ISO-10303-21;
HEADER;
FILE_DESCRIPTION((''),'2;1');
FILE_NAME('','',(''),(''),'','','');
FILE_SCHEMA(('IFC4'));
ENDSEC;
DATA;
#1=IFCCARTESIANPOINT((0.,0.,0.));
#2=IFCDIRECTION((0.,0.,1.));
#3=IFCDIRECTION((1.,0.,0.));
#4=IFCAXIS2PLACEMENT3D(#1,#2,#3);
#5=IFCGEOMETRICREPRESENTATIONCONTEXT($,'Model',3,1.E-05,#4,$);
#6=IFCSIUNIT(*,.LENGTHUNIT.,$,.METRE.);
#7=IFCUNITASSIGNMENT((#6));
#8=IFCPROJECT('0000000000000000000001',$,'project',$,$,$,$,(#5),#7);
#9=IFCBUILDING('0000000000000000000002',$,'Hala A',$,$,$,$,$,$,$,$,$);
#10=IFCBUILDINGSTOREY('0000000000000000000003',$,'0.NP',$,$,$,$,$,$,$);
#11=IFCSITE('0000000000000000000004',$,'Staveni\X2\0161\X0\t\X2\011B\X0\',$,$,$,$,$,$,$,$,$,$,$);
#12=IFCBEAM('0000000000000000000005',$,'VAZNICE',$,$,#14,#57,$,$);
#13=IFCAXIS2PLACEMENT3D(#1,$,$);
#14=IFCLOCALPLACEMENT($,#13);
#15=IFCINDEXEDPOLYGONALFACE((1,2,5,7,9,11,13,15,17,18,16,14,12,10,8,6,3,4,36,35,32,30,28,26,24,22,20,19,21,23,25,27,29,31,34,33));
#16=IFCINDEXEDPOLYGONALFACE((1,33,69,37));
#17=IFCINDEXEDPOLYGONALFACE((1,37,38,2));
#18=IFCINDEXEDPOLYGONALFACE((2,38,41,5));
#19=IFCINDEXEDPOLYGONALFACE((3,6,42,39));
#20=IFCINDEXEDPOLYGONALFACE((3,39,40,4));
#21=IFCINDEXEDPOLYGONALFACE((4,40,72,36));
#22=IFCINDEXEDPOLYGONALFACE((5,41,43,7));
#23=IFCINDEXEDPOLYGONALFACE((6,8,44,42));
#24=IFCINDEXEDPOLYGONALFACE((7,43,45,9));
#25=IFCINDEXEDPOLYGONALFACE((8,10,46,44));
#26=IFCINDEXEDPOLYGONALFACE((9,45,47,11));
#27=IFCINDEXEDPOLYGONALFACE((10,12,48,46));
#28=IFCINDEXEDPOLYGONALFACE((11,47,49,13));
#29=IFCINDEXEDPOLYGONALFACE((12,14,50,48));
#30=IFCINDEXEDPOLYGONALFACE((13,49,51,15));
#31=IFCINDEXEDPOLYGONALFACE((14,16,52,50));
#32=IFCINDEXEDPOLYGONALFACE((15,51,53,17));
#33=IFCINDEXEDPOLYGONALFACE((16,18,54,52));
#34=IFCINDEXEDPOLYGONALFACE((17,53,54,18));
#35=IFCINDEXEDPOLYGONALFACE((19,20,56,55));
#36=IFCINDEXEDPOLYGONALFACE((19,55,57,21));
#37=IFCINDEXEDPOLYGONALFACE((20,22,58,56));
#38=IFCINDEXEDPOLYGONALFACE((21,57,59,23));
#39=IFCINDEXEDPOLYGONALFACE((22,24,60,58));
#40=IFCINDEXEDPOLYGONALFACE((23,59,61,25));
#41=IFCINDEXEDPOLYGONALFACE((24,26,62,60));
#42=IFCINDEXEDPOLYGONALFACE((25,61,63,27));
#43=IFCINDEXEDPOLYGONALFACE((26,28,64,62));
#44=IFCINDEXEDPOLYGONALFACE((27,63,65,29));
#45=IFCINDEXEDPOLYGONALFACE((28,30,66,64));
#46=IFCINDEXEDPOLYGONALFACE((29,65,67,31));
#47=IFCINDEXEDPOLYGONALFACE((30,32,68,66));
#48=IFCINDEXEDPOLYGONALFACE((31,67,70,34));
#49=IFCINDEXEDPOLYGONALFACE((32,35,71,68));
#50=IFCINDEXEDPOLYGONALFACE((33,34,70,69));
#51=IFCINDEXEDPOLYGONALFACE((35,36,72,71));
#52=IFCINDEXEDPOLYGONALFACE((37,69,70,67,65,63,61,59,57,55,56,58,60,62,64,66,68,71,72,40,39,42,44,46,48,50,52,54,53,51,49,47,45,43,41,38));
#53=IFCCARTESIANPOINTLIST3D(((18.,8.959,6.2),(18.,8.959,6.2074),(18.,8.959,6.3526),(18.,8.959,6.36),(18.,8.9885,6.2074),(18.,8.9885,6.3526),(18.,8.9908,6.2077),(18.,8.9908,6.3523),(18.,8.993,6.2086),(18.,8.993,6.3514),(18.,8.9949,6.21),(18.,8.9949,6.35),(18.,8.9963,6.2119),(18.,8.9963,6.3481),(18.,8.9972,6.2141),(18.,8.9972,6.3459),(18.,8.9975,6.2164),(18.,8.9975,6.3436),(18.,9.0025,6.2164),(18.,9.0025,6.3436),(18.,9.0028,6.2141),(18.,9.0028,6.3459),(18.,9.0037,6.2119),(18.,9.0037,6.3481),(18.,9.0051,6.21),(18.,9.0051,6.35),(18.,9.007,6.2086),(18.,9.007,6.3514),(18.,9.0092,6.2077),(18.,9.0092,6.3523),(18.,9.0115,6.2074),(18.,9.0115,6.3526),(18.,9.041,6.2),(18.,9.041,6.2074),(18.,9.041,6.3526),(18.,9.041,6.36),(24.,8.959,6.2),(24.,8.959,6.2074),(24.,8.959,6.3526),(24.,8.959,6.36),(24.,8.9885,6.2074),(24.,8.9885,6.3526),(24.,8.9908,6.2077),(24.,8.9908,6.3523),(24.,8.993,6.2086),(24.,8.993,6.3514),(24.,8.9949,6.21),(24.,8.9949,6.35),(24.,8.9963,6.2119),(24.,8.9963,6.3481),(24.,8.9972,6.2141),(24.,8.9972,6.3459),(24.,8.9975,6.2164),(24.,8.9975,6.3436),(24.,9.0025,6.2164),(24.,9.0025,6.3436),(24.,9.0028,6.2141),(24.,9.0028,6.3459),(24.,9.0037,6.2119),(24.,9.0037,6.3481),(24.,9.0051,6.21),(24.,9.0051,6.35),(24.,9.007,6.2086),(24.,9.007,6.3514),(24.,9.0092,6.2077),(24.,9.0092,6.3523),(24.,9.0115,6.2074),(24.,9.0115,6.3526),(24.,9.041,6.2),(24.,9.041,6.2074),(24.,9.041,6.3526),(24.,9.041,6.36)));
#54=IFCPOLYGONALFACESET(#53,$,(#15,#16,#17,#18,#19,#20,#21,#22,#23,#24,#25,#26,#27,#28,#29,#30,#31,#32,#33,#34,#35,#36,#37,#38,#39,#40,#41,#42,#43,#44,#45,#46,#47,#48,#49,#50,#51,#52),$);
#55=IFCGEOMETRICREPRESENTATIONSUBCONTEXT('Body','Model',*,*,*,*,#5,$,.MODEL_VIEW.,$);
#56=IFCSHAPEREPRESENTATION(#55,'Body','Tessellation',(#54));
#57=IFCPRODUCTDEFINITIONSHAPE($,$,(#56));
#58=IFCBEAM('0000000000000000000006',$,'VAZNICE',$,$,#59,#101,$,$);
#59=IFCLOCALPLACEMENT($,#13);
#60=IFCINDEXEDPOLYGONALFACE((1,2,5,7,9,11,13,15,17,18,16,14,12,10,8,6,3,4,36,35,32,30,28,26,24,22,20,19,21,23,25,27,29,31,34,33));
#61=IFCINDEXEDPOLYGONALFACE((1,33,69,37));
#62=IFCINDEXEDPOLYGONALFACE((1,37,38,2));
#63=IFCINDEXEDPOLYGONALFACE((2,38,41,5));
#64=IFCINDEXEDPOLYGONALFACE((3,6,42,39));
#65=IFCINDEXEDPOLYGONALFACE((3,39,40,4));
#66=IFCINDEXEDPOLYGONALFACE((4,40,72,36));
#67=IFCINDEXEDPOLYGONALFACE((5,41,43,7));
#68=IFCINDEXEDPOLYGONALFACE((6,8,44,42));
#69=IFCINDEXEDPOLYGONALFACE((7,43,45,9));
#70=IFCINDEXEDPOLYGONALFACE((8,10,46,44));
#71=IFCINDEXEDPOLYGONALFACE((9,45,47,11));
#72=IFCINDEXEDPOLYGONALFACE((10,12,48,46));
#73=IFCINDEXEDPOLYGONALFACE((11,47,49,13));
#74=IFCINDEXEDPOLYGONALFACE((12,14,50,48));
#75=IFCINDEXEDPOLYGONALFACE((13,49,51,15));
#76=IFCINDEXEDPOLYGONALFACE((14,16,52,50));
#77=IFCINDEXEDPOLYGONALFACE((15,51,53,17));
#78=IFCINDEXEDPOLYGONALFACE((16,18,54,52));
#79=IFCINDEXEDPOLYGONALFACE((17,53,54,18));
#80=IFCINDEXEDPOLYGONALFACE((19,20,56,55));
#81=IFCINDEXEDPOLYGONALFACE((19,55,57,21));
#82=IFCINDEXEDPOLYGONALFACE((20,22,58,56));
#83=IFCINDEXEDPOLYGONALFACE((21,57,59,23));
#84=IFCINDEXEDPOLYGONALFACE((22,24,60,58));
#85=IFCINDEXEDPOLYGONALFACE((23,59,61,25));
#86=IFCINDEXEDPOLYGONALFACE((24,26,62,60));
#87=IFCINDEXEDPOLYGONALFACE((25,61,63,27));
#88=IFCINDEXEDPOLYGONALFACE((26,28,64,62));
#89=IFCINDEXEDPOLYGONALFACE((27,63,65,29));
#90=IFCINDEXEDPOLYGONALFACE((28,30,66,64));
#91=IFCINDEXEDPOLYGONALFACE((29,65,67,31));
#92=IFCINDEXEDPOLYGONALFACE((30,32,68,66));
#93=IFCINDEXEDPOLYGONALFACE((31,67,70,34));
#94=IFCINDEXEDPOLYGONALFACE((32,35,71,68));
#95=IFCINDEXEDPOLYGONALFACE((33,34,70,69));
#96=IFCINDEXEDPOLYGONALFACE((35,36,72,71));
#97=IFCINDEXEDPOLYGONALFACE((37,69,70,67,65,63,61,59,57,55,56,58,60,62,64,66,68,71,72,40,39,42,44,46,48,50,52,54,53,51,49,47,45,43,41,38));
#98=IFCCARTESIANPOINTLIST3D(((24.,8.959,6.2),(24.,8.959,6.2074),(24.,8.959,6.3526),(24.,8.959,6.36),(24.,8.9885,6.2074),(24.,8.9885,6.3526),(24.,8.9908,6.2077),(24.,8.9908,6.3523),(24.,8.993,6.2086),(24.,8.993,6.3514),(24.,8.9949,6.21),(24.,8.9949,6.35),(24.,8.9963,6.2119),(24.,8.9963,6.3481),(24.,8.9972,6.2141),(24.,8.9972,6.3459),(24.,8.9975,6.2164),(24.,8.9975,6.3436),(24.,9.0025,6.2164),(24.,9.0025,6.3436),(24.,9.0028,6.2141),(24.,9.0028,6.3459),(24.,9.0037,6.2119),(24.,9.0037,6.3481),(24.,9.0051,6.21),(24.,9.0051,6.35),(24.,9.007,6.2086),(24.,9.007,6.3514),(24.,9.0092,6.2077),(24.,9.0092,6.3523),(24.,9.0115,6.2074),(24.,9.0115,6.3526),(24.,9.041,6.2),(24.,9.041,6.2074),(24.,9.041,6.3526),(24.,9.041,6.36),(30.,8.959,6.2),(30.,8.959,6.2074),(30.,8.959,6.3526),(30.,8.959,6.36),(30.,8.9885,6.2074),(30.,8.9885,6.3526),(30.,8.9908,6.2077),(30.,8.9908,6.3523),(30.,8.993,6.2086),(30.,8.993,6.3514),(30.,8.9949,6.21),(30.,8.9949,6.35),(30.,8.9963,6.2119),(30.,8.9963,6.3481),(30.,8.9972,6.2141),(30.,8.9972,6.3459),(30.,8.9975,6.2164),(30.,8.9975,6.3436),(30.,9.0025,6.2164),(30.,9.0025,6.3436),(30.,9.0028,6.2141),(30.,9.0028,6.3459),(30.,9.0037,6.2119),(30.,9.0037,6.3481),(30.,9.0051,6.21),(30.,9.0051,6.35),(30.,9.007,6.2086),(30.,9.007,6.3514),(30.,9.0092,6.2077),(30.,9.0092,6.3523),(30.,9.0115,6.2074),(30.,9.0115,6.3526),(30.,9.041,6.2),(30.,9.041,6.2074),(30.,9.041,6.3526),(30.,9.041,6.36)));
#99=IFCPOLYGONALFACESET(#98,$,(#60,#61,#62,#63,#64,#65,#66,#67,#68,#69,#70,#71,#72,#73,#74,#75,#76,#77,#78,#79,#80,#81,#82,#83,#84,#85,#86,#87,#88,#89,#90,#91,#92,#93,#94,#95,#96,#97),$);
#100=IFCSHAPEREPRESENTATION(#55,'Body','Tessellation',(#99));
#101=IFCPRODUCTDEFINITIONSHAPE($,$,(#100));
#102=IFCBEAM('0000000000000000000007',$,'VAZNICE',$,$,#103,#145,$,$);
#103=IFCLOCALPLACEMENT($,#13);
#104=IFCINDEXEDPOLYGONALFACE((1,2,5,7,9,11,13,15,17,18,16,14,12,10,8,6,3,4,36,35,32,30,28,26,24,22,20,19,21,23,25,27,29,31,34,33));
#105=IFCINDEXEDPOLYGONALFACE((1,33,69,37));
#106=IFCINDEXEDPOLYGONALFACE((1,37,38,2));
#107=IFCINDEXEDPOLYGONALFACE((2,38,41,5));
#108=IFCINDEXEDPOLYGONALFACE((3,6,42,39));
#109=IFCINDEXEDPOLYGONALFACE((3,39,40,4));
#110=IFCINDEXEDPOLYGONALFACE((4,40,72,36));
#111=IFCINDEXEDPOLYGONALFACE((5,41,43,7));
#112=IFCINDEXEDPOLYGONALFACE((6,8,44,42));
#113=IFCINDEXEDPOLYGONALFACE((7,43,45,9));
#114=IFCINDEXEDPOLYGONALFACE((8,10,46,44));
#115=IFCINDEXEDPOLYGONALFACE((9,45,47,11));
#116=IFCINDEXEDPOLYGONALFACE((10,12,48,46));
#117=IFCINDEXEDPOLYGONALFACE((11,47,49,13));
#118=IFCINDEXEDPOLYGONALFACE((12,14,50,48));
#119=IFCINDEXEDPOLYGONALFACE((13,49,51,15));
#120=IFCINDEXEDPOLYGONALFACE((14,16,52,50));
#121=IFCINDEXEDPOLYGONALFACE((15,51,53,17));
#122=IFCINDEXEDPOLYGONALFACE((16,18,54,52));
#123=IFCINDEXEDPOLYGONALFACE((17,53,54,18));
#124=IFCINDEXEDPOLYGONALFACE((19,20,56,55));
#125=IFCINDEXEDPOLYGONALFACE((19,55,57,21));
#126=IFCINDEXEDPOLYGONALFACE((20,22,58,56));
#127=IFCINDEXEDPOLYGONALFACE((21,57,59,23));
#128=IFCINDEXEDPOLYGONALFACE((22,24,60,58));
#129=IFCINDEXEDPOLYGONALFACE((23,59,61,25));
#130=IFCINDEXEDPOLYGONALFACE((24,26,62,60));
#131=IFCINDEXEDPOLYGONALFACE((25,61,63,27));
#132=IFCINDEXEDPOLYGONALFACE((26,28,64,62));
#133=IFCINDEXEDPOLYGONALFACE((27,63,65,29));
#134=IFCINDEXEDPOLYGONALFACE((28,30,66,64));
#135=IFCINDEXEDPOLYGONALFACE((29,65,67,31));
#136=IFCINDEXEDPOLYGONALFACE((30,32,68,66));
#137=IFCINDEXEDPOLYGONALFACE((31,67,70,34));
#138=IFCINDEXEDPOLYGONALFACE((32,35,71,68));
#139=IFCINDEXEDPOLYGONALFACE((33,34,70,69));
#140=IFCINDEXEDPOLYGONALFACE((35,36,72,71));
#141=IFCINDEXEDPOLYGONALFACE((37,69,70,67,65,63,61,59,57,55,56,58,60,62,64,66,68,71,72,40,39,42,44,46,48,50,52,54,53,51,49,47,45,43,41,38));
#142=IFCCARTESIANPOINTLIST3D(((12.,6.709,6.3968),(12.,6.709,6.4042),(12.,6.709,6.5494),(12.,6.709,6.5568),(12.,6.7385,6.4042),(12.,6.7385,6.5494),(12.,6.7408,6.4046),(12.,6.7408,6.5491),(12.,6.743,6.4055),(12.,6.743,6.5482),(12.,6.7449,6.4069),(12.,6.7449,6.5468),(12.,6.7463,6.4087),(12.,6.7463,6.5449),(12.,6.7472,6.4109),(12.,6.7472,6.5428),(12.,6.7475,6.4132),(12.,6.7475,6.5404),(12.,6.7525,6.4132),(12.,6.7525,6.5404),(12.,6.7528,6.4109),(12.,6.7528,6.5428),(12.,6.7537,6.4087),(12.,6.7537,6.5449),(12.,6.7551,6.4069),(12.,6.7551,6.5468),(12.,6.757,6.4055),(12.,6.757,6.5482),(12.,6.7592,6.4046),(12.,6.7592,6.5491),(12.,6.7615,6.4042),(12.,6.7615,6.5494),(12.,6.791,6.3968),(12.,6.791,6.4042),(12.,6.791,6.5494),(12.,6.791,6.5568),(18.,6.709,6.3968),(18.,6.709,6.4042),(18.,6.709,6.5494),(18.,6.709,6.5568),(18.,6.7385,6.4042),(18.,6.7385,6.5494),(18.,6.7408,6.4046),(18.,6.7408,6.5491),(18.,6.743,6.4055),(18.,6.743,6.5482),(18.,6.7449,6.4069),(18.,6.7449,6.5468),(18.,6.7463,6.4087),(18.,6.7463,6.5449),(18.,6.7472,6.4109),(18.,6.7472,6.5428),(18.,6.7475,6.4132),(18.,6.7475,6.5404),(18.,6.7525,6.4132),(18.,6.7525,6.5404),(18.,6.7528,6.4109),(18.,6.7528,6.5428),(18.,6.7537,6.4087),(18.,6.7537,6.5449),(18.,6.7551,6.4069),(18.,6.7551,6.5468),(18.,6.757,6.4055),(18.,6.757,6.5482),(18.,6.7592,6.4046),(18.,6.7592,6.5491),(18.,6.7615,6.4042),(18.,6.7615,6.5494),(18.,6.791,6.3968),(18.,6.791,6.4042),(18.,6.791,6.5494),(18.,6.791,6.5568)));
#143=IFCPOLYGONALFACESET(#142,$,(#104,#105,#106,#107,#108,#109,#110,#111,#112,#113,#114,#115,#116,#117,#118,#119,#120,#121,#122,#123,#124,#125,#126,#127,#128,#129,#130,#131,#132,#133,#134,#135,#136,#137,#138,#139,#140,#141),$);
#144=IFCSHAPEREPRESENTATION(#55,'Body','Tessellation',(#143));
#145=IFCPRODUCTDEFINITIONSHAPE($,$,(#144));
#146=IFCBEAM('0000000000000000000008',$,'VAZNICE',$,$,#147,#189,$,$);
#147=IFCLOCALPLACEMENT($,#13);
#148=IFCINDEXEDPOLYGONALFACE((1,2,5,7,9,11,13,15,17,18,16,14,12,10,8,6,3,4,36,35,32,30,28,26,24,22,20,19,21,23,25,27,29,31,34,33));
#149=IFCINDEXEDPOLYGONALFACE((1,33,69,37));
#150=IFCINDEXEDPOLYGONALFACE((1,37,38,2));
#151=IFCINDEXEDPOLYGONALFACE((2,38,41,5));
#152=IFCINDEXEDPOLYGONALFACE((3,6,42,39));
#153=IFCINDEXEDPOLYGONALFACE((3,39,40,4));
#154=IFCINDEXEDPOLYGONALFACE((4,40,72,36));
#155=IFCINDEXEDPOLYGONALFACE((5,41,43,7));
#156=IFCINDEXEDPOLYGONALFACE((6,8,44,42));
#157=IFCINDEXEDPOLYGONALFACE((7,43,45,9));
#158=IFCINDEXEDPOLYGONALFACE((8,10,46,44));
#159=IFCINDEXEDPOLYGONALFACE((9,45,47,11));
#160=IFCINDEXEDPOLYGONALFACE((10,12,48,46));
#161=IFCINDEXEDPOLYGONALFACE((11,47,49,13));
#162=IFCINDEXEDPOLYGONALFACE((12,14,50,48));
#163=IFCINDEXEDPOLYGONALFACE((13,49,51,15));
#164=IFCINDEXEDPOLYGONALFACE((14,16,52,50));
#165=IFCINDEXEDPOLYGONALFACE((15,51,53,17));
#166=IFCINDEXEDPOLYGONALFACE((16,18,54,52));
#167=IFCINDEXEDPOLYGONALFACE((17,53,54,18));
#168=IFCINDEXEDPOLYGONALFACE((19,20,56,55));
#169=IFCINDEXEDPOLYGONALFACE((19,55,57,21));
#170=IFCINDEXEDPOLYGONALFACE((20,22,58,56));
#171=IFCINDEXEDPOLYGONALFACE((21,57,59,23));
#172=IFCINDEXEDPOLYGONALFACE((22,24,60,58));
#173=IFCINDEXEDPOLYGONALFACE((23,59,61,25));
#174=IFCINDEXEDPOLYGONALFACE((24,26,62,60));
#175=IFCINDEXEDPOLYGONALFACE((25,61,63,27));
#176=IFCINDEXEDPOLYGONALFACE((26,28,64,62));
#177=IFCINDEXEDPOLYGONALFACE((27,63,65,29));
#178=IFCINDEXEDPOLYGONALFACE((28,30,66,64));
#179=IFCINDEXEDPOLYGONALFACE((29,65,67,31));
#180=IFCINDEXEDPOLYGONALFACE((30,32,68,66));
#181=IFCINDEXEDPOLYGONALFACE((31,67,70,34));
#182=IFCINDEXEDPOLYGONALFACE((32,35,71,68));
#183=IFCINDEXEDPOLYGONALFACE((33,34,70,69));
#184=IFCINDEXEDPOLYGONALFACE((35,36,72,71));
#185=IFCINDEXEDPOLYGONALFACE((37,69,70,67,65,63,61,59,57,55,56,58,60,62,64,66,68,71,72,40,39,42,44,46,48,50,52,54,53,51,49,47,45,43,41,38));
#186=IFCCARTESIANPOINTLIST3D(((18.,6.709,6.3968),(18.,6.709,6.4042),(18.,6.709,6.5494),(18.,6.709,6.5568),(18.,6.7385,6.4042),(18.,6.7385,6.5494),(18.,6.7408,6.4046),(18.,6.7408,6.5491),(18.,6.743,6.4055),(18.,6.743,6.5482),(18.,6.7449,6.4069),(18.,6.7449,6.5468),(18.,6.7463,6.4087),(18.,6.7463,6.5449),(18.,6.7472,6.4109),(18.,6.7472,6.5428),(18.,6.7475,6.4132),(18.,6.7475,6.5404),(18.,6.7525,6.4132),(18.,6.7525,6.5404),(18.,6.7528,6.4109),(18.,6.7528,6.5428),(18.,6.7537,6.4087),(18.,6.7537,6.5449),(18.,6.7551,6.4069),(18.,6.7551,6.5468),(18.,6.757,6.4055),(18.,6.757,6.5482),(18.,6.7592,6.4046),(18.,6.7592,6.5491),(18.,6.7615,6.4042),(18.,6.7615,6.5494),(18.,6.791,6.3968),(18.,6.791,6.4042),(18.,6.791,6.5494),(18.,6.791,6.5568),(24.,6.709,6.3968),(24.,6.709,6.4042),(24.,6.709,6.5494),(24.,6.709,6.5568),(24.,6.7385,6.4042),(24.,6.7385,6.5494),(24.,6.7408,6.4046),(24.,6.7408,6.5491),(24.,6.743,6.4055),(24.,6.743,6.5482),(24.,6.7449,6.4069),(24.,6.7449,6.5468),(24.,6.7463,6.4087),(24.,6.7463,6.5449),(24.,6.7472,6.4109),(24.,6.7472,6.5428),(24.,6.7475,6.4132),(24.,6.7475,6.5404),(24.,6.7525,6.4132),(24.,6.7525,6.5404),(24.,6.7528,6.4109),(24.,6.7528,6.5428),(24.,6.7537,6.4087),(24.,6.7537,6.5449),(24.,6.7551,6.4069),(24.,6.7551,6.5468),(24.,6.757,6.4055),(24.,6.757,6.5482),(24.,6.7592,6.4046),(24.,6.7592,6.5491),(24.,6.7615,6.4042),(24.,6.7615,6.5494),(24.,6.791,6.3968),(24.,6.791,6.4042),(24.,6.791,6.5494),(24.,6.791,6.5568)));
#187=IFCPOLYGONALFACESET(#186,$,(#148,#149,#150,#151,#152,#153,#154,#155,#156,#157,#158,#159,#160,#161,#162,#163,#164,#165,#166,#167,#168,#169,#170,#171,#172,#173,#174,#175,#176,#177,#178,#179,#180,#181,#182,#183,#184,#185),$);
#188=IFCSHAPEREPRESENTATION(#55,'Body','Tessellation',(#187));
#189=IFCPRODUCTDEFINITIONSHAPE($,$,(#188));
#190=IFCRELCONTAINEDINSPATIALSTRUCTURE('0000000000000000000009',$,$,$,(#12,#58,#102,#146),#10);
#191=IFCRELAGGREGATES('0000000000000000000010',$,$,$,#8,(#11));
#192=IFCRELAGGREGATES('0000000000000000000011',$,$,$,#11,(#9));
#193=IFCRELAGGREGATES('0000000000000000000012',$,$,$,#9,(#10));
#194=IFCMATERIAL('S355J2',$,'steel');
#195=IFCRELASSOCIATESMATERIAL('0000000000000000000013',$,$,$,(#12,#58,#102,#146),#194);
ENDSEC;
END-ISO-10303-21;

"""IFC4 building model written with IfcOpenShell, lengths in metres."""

from ifc_helpers import new_model, si_unit, frame, origin_with_axes, place, context, subcontext, project, spatial, i_section, extrude, material, element, save


model = new_model("IFC4")

# Units and contexts
model_context = context("Model", 3, precision=1e-05, world=origin_with_axes())
body_context = subcontext(model_context, "Body", "Model", "MODEL_VIEW")
ifc_project = project(units=[si_unit("LENGTHUNIT", "METRE")], contexts=[model_context])

# Site, building, storey
site = spatial("IfcSite", under=ifc_project, Name="Staveniště")
building = spatial("IfcBuilding", under=site, Name="Hala A")
storey = spatial("IfcBuildingStorey", under=building, Name="0.NP")

# Shared definitions
ifc_material_1 = material(Name="S355J2", Category="steel")

# Beams
for number, where, z_axis, x_axis, name in (
    (1, (18.0, 9.0, 6.28), (1.0, 0.0, 0.0), (0.0, 1.0, 0.0), "VAZNICE"),
    (2, (24.0, 9.0, 6.28), (1.0, 0.0, 0.0), (0.0, 1.0, 0.0), "VAZNICE"),
    (3, (12.0, 6.75, 6.4768), (1.0, 0.0, 0.0), (0.0, 1.0, 0.0), "VAZNICE"),
    (4, (18.0, 6.75, 6.4768), (1.0, 0.0, 0.0), (0.0, 1.0, 0.0), "VAZNICE"),
):
    element("IfcBeam", number, at=place(None, frame(where, z_axis=z_axis, x_axis=x_axis)), inside=storey, material=ifc_material_1, Name=name, context=body_context, shape_type="SweptSolid", body=[
        extrude(i_section(OverallWidth=0.082, OverallDepth=0.16, WebThickness=0.005, FlangeThickness=0.0074, FilletRadius=0.009), origin_with_axes(), (0.0, 0.0, 1.0), 6.0),
    ])

save(model, "model.ifc")
